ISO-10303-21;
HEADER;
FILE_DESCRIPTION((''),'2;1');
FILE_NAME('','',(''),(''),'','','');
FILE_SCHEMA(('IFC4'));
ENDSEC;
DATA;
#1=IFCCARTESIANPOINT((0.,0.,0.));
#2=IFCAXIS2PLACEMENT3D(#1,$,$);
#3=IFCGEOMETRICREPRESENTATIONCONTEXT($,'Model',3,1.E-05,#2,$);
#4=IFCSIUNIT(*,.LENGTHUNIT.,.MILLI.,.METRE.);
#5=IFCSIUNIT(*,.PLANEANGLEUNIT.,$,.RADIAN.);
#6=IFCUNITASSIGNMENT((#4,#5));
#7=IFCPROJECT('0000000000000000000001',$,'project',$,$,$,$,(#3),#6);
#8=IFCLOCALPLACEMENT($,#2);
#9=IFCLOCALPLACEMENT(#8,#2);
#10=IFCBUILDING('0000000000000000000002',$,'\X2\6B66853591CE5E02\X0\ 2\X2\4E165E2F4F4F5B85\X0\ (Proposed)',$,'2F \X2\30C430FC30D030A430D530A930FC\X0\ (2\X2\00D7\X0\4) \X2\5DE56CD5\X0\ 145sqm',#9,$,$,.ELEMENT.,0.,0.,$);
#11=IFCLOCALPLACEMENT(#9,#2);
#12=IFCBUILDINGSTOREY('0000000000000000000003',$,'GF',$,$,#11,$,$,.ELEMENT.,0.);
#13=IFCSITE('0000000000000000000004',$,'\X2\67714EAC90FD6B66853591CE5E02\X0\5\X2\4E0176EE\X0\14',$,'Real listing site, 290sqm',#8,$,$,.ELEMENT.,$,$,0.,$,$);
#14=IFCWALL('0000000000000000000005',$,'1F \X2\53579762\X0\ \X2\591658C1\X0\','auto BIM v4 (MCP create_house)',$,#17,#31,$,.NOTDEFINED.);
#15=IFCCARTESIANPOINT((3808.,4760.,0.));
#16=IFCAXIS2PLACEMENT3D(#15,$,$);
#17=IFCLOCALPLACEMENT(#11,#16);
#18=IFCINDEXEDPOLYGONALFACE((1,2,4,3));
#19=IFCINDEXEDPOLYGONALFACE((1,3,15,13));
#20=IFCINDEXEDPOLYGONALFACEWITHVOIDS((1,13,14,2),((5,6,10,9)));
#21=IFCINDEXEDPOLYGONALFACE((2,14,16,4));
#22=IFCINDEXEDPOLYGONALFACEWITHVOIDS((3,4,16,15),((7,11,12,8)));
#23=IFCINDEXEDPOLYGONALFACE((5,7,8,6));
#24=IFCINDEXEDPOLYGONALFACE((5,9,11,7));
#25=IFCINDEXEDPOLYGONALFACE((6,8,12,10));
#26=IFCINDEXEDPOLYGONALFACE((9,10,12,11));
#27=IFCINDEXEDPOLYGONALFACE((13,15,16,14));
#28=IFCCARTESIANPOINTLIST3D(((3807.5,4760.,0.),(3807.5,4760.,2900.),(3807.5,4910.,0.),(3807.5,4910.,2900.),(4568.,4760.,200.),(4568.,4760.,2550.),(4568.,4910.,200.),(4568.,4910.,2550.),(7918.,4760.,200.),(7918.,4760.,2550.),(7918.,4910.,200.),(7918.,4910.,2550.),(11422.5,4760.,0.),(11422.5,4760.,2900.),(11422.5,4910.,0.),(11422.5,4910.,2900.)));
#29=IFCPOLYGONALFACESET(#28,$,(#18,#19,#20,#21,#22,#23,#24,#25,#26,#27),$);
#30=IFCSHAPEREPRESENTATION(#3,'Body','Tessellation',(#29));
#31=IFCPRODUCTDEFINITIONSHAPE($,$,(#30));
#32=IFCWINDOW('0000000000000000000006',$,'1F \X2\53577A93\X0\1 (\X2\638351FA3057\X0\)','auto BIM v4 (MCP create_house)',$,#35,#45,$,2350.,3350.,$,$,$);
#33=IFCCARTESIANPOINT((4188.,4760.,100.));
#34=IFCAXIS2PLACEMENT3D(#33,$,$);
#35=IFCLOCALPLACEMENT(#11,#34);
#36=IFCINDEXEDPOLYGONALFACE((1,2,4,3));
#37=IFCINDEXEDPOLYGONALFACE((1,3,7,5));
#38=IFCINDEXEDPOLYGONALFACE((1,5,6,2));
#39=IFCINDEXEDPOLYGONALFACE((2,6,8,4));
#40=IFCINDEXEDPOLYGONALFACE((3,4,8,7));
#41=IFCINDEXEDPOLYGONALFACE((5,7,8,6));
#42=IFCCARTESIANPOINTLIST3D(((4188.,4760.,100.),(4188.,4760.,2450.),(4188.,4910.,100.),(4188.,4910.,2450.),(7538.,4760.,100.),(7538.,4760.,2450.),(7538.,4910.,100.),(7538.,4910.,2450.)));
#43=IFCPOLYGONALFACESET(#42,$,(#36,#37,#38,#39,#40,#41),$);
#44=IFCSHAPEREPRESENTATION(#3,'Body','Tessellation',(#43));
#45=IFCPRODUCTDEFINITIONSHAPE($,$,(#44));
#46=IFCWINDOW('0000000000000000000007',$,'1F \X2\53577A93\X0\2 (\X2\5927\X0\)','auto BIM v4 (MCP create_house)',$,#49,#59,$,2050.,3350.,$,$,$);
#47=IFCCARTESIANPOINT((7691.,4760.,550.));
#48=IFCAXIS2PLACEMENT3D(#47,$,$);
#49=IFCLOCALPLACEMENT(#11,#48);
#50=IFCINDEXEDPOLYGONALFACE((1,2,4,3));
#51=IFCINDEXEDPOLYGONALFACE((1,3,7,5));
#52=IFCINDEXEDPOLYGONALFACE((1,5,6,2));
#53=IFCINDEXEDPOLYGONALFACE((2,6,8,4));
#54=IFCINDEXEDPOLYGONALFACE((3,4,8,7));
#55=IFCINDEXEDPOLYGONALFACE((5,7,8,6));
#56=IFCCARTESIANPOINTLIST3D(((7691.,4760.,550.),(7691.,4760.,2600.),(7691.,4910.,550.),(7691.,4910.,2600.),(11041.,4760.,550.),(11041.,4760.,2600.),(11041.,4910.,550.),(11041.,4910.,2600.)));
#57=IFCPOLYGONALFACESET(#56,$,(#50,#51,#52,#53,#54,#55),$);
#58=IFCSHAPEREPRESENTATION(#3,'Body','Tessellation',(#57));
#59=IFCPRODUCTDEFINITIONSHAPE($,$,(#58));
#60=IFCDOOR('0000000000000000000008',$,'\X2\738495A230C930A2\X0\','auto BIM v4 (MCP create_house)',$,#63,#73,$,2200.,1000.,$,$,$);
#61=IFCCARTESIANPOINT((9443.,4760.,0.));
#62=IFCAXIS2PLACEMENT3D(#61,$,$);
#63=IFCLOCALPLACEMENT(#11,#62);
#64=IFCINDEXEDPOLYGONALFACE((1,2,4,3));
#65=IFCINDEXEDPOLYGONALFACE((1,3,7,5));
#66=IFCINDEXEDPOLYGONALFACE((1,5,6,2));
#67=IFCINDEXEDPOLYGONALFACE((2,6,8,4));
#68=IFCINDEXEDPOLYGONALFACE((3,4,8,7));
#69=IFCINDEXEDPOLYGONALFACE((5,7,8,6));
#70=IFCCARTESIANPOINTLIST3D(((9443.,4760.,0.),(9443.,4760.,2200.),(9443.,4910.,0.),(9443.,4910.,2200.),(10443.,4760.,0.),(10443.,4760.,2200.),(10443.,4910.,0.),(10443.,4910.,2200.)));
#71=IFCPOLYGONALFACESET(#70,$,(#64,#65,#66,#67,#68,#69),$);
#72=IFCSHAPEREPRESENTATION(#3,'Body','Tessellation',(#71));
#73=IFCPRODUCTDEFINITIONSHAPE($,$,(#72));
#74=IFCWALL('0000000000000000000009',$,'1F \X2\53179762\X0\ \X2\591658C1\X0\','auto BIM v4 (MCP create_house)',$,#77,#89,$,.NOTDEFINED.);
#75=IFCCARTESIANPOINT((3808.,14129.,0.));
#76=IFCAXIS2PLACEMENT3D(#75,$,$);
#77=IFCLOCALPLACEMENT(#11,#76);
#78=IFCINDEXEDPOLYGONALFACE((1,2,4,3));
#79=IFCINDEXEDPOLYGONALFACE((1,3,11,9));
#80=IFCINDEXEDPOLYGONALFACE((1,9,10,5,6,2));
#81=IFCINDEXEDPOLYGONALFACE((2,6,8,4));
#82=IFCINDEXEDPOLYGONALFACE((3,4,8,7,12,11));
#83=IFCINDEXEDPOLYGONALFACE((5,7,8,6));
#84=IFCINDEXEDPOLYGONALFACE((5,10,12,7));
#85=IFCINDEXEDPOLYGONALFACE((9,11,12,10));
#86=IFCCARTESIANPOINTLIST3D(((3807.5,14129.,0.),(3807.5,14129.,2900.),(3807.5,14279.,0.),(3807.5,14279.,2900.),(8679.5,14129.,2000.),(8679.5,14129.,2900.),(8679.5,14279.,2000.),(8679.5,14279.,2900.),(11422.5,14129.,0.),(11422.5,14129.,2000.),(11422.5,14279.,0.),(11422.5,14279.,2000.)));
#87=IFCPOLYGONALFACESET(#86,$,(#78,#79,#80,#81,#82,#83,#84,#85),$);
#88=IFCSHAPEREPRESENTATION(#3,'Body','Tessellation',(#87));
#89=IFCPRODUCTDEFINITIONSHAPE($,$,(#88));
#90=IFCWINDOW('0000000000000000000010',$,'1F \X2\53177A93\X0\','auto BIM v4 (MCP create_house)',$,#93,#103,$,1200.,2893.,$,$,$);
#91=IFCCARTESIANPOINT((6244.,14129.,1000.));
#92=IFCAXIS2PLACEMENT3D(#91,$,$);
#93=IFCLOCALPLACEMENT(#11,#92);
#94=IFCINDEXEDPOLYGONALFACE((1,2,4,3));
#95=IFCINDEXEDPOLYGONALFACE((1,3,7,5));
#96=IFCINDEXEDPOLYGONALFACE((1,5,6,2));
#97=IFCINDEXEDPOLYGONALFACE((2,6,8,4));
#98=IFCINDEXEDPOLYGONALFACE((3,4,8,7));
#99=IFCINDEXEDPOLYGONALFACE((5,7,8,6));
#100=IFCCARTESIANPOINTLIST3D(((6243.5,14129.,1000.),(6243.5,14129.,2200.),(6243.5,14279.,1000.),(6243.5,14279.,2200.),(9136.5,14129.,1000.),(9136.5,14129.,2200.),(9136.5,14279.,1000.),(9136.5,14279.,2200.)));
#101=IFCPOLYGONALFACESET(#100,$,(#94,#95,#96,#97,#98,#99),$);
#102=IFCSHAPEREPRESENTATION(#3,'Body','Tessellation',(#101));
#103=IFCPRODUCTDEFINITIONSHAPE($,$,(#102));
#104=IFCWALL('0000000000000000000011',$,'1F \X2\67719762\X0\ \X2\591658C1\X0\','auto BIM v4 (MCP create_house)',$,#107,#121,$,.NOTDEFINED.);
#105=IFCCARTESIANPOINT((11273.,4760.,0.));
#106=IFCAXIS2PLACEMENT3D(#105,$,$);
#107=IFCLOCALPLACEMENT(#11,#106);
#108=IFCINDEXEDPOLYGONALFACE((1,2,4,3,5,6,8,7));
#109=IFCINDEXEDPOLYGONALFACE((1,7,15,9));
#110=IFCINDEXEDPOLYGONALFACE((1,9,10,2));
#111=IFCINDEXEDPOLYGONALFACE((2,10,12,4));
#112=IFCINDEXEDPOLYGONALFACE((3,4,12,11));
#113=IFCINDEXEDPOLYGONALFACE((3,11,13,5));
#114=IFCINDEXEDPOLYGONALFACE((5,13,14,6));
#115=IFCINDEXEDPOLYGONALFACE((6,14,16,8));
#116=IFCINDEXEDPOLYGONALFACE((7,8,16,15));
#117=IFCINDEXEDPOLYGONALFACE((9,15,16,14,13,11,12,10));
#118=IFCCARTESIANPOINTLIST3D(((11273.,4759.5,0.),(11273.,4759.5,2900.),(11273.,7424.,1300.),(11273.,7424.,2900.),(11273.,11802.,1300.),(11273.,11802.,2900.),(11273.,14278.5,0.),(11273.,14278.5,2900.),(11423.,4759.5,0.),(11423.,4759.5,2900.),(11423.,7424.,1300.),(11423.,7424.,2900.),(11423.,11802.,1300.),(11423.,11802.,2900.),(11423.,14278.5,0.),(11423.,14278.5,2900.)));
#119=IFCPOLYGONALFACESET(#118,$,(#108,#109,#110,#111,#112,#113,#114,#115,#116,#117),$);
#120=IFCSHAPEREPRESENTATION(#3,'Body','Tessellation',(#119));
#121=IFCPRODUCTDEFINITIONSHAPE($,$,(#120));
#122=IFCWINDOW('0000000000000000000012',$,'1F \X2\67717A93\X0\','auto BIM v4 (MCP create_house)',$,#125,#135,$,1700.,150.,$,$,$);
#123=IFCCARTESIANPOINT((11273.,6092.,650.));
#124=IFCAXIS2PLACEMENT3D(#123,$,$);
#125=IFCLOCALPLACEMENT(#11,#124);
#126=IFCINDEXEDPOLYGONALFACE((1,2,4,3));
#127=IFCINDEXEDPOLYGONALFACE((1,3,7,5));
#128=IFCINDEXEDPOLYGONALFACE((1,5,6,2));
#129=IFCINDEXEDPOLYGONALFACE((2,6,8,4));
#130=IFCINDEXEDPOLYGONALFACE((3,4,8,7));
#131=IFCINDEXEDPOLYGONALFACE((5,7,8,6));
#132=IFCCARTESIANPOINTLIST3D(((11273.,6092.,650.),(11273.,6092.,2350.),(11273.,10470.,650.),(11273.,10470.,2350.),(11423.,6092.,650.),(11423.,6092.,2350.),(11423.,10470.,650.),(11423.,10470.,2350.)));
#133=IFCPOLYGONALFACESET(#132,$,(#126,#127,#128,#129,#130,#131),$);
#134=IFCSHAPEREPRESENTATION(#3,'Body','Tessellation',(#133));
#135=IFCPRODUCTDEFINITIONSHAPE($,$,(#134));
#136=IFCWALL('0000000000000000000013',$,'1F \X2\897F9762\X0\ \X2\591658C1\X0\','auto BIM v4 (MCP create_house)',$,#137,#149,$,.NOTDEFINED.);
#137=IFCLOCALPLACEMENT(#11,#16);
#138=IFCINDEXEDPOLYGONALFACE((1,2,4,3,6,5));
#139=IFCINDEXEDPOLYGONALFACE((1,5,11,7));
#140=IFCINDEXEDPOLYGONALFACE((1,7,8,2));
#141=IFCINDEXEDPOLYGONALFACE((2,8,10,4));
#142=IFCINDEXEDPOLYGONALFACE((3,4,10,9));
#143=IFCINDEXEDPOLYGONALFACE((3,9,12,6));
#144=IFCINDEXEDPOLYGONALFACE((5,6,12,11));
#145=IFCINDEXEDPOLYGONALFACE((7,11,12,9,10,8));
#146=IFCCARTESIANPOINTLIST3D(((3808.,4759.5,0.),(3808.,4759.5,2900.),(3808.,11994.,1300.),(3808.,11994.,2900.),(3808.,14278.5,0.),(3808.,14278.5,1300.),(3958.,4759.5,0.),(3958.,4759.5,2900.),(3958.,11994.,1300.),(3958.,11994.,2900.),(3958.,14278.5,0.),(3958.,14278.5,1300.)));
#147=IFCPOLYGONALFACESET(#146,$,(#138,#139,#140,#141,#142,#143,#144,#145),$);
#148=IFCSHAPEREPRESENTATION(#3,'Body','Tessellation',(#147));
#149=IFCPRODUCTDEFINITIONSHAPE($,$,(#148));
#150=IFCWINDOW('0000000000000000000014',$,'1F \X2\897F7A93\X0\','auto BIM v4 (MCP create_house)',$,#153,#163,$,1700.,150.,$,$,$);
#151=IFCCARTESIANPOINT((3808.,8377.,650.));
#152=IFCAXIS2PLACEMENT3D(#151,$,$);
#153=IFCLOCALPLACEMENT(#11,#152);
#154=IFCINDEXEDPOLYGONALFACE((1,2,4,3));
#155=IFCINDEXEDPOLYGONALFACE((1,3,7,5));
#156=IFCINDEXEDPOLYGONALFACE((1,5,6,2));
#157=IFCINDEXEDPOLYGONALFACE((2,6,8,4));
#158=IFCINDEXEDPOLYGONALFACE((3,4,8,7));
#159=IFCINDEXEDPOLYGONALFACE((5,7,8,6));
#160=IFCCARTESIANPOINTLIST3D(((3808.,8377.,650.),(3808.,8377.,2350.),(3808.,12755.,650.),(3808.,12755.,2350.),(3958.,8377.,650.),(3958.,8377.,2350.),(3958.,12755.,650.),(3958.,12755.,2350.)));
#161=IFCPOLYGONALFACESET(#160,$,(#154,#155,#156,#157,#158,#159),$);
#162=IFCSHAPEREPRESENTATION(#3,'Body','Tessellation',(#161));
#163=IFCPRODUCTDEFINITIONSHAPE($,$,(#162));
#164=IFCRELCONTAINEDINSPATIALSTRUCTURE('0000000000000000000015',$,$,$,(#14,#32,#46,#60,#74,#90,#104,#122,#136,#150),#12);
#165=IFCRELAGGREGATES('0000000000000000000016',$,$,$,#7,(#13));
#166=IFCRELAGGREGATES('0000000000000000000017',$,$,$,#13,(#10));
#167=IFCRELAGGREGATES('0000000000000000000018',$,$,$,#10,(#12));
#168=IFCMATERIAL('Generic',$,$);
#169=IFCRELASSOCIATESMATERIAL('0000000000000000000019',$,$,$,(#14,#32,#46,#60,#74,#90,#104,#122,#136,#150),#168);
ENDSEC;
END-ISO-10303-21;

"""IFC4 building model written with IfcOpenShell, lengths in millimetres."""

from ifc_helpers import new_model, si_unit, frame, frame_2d, origin, place, context, project, spatial, rectangle, extrude, material, element, fill, save


model = new_model("IFC4")

# Units and contexts
model_context = context("Model", 3, precision=1e-05, world=origin())
ifc_project = project(units=[si_unit("LENGTHUNIT", "METRE", prefix="MILLI"), si_unit("PLANEANGLEUNIT", "RADIAN")], contexts=[model_context])

# Site, building, storey
site_placement = place(None, origin())
site = spatial("IfcSite", under=ifc_project, at=site_placement, Name="東京都武蔵野市5丁目14", ObjectType="Real listing site, 290sqm", CompositionType="ELEMENT", RefElevation=0.0)
building_placement = place(site_placement, origin())
building = spatial("IfcBuilding", under=site, at=building_placement, Name="武蔵野市 2世帯住宅 (Proposed)", ObjectType="2F ツーバイフォー (2×4) 工法 145sqm", CompositionType="ELEMENT", ElevationOfRefHeight=0.0, ElevationOfTerrain=0.0)
storey_placement = place(building_placement, origin())
storey = spatial("IfcBuildingStorey", under=building, at=storey_placement, Name="GF", CompositionType="ELEMENT", Elevation=0.0)

# Shared definitions
ifc_material = material(Name="Generic")

# Wall, openings, windows, door
wall_1_placement = place(storey_placement, frame((3808.0, 4760.0, 0.0)))
wall_1 = element("IfcWall", 1, at=wall_1_placement, inside=storey, material=ifc_material, Name="1F 南面 外壁", Description="auto BIM v4 (MCP create_house)", PredefinedType="NOTDEFINED", context=model_context, shape_type="SweptSolid", body=[
    extrude(rectangle(XDim=7615.0, YDim=150.0, at=frame_2d((3807.0, 75.0))), frame((3808.0, 4760.0, 0.0)), (0.0, 0.0, 1.0), 2900.0),
])
opening_1_placement = place(storey_placement, frame((4188.0, 4760.0, 100.0)))
opening_1 = element("IfcOpeningElement", 2, at=opening_1_placement, cuts=wall_1, PredefinedType="NOTDEFINED", context=model_context, shape_type="SweptSolid", body=[
    extrude(rectangle(XDim=3350.0, YDim=150.0, at=frame_2d((1675.0, 75.0))), frame((4188.0, 4760.0, 100.0)), (0.0, 0.0, 1.0), 2350.0),
])
opening_2_placement = place(storey_placement, frame((7691.0, 4760.0, 550.0)))
opening_2 = element("IfcOpeningElement", 3, at=opening_2_placement, cuts=wall_1, PredefinedType="NOTDEFINED", context=model_context, shape_type="SweptSolid", body=[
    extrude(rectangle(XDim=3350.0, YDim=150.0, at=frame_2d((1675.0, 75.0))), frame((7691.0, 4760.0, 550.0)), (0.0, 0.0, 1.0), 2050.0),
])
opening_3_placement = place(storey_placement, frame((9443.0, 4760.0, 0.0)))
opening_3 = element("IfcOpeningElement", 4, at=opening_3_placement, cuts=wall_1, PredefinedType="NOTDEFINED", context=model_context, shape_type="SweptSolid", body=[
    extrude(rectangle(XDim=1000.0, YDim=150.0, at=frame_2d((500.0, 75.0))), frame((9443.0, 4760.0, 0.0)), (0.0, 0.0, 1.0), 2200.0),
])
window_1_placement = place(storey_placement, frame((4188.0, 4760.0, 100.0)))
window_1 = element("IfcWindow", 5, at=window_1_placement, inside=storey, material=ifc_material, Name="1F 南窓1 (掃出し)", Description="auto BIM v4 (MCP create_house)", OverallHeight=2350.0, OverallWidth=3350.0, context=model_context, shape_type="SweptSolid", body=[
    extrude(rectangle(XDim=3350.0, YDim=150.0, at=frame_2d((1675.0, 75.0))), frame((4188.0, 4760.0, 100.0)), (0.0, 0.0, 1.0), 2350.0),
])
fill(opening_1, window_1)
window_2_placement = place(storey_placement, frame((7691.0, 4760.0, 550.0)))
window_2 = element("IfcWindow", 6, at=window_2_placement, inside=storey, material=ifc_material, Name="1F 南窓2 (大)", Description="auto BIM v4 (MCP create_house)", OverallHeight=2050.0, OverallWidth=3350.0, context=model_context, shape_type="SweptSolid", body=[
    extrude(rectangle(XDim=3350.0, YDim=150.0, at=frame_2d((1675.0, 75.0))), frame((7691.0, 4760.0, 550.0)), (0.0, 0.0, 1.0), 2050.0),
])
fill(opening_2, window_2)
door_1_placement = place(storey_placement, frame((9443.0, 4760.0, 0.0)))
door_1 = element("IfcDoor", 7, at=door_1_placement, inside=storey, material=ifc_material, Name="玄関ドア", Description="auto BIM v4 (MCP create_house)", OverallHeight=2200.0, OverallWidth=1000.0, context=model_context, shape_type="SweptSolid", body=[
    extrude(rectangle(XDim=1000.0, YDim=150.0, at=frame_2d((500.0, 75.0))), frame((9443.0, 4760.0, 0.0)), (0.0, 0.0, 1.0), 2200.0),
])
fill(opening_3, door_1)

# Walls, openings, windows
wall_2_placement = place(storey_placement, frame((3808.0, 14129.0, 0.0)))
wall_2 = element("IfcWall", 8, at=wall_2_placement, inside=storey, material=ifc_material, Name="1F 北面 外壁", Description="auto BIM v4 (MCP create_house)", PredefinedType="NOTDEFINED", context=model_context, shape_type="SweptSolid", body=[
    extrude(rectangle(XDim=7615.0, YDim=150.0, at=frame_2d((3807.0, 75.0))), frame((3808.0, 14129.0, 0.0)), (0.0, 0.0, 1.0), 2900.0),
])
opening_4_placement = place(storey_placement, frame((6244.0, 14129.0, 1000.0)))
opening_4 = element("IfcOpeningElement", 9, at=opening_4_placement, cuts=wall_2, PredefinedType="NOTDEFINED", context=model_context, shape_type="SweptSolid", body=[
    extrude(rectangle(XDim=2893.0, YDim=150.0, at=frame_2d((1446.0, 75.0))), frame((6244.0, 14129.0, 1000.0)), (0.0, 0.0, 1.0), 1200.0),
])
window_3_placement = place(storey_placement, frame((6244.0, 14129.0, 1000.0)))
window_3 = element("IfcWindow", 10, at=window_3_placement, inside=storey, material=ifc_material, Name="1F 北窓", Description="auto BIM v4 (MCP create_house)", OverallHeight=1200.0, OverallWidth=2893.0, context=model_context, shape_type="SweptSolid", body=[
    extrude(rectangle(XDim=2893.0, YDim=150.0, at=frame_2d((1446.0, 75.0))), frame((6244.0, 14129.0, 1000.0)), (0.0, 0.0, 1.0), 1200.0),
])
fill(opening_4, window_3)
wall_3_placement = place(storey_placement, frame((11273.0, 4760.0, 0.0)))
wall_3 = element("IfcWall", 11, at=wall_3_placement, inside=storey, material=ifc_material, Name="1F 東面 外壁", Description="auto BIM v4 (MCP create_house)", PredefinedType="NOTDEFINED", context=model_context, shape_type="SweptSolid", body=[
    extrude(rectangle(XDim=150.0, YDim=9519.0, at=frame_2d((75.0, 4759.0))), frame((11273.0, 4760.0, 0.0)), (0.0, 0.0, 1.0), 2900.0),
])
opening_5_placement = place(storey_placement, frame((11273.0, 6092.0, 650.0)))
opening_5 = element("IfcOpeningElement", 12, at=opening_5_placement, cuts=wall_3, PredefinedType="NOTDEFINED", context=model_context, shape_type="SweptSolid", body=[
    extrude(rectangle(XDim=150.0, YDim=4378.0, at=frame_2d((75.0, 2189.0))), frame((11273.0, 6092.0, 650.0)), (0.0, 0.0, 1.0), 1700.0),
])
window_4_placement = place(storey_placement, frame((11273.0, 6092.0, 650.0)))
window_4 = element("IfcWindow", 13, at=window_4_placement, inside=storey, material=ifc_material, Name="1F 東窓", Description="auto BIM v4 (MCP create_house)", OverallHeight=1700.0, OverallWidth=150.0, context=model_context, shape_type="SweptSolid", body=[
    extrude(rectangle(XDim=150.0, YDim=4378.0, at=frame_2d((75.0, 2189.0))), frame((11273.0, 6092.0, 650.0)), (0.0, 0.0, 1.0), 1700.0),
])
fill(opening_5, window_4)
wall_4_placement = place(storey_placement, frame((3808.0, 4760.0, 0.0)))
wall_4 = element("IfcWall", 14, at=wall_4_placement, inside=storey, material=ifc_material, Name="1F 西面 外壁", Description="auto BIM v4 (MCP create_house)", PredefinedType="NOTDEFINED", context=model_context, shape_type="SweptSolid", body=[
    extrude(rectangle(XDim=150.0, YDim=9519.0, at=frame_2d((75.0, 4759.0))), frame((3808.0, 4760.0, 0.0)), (0.0, 0.0, 1.0), 2900.0),
])
opening_6_placement = place(storey_placement, frame((3808.0, 8377.0, 650.0)))
opening_6 = element("IfcOpeningElement", 15, at=opening_6_placement, cuts=wall_4, PredefinedType="NOTDEFINED", context=model_context, shape_type="SweptSolid", body=[
    extrude(rectangle(XDim=150.0, YDim=4378.0, at=frame_2d((75.0, 2189.0))), frame((3808.0, 8377.0, 650.0)), (0.0, 0.0, 1.0), 1700.0),
])
window_5_placement = place(storey_placement, frame((3808.0, 8377.0, 650.0)))
window_5 = element("IfcWindow", 16, at=window_5_placement, inside=storey, material=ifc_material, Name="1F 西窓", Description="auto BIM v4 (MCP create_house)", OverallHeight=1700.0, OverallWidth=150.0, context=model_context, shape_type="SweptSolid", body=[
    extrude(rectangle(XDim=150.0, YDim=4378.0, at=frame_2d((75.0, 2189.0))), frame((3808.0, 8377.0, 650.0)), (0.0, 0.0, 1.0), 1700.0),
])
fill(opening_6, window_5)

save(model, "model.ifc")
